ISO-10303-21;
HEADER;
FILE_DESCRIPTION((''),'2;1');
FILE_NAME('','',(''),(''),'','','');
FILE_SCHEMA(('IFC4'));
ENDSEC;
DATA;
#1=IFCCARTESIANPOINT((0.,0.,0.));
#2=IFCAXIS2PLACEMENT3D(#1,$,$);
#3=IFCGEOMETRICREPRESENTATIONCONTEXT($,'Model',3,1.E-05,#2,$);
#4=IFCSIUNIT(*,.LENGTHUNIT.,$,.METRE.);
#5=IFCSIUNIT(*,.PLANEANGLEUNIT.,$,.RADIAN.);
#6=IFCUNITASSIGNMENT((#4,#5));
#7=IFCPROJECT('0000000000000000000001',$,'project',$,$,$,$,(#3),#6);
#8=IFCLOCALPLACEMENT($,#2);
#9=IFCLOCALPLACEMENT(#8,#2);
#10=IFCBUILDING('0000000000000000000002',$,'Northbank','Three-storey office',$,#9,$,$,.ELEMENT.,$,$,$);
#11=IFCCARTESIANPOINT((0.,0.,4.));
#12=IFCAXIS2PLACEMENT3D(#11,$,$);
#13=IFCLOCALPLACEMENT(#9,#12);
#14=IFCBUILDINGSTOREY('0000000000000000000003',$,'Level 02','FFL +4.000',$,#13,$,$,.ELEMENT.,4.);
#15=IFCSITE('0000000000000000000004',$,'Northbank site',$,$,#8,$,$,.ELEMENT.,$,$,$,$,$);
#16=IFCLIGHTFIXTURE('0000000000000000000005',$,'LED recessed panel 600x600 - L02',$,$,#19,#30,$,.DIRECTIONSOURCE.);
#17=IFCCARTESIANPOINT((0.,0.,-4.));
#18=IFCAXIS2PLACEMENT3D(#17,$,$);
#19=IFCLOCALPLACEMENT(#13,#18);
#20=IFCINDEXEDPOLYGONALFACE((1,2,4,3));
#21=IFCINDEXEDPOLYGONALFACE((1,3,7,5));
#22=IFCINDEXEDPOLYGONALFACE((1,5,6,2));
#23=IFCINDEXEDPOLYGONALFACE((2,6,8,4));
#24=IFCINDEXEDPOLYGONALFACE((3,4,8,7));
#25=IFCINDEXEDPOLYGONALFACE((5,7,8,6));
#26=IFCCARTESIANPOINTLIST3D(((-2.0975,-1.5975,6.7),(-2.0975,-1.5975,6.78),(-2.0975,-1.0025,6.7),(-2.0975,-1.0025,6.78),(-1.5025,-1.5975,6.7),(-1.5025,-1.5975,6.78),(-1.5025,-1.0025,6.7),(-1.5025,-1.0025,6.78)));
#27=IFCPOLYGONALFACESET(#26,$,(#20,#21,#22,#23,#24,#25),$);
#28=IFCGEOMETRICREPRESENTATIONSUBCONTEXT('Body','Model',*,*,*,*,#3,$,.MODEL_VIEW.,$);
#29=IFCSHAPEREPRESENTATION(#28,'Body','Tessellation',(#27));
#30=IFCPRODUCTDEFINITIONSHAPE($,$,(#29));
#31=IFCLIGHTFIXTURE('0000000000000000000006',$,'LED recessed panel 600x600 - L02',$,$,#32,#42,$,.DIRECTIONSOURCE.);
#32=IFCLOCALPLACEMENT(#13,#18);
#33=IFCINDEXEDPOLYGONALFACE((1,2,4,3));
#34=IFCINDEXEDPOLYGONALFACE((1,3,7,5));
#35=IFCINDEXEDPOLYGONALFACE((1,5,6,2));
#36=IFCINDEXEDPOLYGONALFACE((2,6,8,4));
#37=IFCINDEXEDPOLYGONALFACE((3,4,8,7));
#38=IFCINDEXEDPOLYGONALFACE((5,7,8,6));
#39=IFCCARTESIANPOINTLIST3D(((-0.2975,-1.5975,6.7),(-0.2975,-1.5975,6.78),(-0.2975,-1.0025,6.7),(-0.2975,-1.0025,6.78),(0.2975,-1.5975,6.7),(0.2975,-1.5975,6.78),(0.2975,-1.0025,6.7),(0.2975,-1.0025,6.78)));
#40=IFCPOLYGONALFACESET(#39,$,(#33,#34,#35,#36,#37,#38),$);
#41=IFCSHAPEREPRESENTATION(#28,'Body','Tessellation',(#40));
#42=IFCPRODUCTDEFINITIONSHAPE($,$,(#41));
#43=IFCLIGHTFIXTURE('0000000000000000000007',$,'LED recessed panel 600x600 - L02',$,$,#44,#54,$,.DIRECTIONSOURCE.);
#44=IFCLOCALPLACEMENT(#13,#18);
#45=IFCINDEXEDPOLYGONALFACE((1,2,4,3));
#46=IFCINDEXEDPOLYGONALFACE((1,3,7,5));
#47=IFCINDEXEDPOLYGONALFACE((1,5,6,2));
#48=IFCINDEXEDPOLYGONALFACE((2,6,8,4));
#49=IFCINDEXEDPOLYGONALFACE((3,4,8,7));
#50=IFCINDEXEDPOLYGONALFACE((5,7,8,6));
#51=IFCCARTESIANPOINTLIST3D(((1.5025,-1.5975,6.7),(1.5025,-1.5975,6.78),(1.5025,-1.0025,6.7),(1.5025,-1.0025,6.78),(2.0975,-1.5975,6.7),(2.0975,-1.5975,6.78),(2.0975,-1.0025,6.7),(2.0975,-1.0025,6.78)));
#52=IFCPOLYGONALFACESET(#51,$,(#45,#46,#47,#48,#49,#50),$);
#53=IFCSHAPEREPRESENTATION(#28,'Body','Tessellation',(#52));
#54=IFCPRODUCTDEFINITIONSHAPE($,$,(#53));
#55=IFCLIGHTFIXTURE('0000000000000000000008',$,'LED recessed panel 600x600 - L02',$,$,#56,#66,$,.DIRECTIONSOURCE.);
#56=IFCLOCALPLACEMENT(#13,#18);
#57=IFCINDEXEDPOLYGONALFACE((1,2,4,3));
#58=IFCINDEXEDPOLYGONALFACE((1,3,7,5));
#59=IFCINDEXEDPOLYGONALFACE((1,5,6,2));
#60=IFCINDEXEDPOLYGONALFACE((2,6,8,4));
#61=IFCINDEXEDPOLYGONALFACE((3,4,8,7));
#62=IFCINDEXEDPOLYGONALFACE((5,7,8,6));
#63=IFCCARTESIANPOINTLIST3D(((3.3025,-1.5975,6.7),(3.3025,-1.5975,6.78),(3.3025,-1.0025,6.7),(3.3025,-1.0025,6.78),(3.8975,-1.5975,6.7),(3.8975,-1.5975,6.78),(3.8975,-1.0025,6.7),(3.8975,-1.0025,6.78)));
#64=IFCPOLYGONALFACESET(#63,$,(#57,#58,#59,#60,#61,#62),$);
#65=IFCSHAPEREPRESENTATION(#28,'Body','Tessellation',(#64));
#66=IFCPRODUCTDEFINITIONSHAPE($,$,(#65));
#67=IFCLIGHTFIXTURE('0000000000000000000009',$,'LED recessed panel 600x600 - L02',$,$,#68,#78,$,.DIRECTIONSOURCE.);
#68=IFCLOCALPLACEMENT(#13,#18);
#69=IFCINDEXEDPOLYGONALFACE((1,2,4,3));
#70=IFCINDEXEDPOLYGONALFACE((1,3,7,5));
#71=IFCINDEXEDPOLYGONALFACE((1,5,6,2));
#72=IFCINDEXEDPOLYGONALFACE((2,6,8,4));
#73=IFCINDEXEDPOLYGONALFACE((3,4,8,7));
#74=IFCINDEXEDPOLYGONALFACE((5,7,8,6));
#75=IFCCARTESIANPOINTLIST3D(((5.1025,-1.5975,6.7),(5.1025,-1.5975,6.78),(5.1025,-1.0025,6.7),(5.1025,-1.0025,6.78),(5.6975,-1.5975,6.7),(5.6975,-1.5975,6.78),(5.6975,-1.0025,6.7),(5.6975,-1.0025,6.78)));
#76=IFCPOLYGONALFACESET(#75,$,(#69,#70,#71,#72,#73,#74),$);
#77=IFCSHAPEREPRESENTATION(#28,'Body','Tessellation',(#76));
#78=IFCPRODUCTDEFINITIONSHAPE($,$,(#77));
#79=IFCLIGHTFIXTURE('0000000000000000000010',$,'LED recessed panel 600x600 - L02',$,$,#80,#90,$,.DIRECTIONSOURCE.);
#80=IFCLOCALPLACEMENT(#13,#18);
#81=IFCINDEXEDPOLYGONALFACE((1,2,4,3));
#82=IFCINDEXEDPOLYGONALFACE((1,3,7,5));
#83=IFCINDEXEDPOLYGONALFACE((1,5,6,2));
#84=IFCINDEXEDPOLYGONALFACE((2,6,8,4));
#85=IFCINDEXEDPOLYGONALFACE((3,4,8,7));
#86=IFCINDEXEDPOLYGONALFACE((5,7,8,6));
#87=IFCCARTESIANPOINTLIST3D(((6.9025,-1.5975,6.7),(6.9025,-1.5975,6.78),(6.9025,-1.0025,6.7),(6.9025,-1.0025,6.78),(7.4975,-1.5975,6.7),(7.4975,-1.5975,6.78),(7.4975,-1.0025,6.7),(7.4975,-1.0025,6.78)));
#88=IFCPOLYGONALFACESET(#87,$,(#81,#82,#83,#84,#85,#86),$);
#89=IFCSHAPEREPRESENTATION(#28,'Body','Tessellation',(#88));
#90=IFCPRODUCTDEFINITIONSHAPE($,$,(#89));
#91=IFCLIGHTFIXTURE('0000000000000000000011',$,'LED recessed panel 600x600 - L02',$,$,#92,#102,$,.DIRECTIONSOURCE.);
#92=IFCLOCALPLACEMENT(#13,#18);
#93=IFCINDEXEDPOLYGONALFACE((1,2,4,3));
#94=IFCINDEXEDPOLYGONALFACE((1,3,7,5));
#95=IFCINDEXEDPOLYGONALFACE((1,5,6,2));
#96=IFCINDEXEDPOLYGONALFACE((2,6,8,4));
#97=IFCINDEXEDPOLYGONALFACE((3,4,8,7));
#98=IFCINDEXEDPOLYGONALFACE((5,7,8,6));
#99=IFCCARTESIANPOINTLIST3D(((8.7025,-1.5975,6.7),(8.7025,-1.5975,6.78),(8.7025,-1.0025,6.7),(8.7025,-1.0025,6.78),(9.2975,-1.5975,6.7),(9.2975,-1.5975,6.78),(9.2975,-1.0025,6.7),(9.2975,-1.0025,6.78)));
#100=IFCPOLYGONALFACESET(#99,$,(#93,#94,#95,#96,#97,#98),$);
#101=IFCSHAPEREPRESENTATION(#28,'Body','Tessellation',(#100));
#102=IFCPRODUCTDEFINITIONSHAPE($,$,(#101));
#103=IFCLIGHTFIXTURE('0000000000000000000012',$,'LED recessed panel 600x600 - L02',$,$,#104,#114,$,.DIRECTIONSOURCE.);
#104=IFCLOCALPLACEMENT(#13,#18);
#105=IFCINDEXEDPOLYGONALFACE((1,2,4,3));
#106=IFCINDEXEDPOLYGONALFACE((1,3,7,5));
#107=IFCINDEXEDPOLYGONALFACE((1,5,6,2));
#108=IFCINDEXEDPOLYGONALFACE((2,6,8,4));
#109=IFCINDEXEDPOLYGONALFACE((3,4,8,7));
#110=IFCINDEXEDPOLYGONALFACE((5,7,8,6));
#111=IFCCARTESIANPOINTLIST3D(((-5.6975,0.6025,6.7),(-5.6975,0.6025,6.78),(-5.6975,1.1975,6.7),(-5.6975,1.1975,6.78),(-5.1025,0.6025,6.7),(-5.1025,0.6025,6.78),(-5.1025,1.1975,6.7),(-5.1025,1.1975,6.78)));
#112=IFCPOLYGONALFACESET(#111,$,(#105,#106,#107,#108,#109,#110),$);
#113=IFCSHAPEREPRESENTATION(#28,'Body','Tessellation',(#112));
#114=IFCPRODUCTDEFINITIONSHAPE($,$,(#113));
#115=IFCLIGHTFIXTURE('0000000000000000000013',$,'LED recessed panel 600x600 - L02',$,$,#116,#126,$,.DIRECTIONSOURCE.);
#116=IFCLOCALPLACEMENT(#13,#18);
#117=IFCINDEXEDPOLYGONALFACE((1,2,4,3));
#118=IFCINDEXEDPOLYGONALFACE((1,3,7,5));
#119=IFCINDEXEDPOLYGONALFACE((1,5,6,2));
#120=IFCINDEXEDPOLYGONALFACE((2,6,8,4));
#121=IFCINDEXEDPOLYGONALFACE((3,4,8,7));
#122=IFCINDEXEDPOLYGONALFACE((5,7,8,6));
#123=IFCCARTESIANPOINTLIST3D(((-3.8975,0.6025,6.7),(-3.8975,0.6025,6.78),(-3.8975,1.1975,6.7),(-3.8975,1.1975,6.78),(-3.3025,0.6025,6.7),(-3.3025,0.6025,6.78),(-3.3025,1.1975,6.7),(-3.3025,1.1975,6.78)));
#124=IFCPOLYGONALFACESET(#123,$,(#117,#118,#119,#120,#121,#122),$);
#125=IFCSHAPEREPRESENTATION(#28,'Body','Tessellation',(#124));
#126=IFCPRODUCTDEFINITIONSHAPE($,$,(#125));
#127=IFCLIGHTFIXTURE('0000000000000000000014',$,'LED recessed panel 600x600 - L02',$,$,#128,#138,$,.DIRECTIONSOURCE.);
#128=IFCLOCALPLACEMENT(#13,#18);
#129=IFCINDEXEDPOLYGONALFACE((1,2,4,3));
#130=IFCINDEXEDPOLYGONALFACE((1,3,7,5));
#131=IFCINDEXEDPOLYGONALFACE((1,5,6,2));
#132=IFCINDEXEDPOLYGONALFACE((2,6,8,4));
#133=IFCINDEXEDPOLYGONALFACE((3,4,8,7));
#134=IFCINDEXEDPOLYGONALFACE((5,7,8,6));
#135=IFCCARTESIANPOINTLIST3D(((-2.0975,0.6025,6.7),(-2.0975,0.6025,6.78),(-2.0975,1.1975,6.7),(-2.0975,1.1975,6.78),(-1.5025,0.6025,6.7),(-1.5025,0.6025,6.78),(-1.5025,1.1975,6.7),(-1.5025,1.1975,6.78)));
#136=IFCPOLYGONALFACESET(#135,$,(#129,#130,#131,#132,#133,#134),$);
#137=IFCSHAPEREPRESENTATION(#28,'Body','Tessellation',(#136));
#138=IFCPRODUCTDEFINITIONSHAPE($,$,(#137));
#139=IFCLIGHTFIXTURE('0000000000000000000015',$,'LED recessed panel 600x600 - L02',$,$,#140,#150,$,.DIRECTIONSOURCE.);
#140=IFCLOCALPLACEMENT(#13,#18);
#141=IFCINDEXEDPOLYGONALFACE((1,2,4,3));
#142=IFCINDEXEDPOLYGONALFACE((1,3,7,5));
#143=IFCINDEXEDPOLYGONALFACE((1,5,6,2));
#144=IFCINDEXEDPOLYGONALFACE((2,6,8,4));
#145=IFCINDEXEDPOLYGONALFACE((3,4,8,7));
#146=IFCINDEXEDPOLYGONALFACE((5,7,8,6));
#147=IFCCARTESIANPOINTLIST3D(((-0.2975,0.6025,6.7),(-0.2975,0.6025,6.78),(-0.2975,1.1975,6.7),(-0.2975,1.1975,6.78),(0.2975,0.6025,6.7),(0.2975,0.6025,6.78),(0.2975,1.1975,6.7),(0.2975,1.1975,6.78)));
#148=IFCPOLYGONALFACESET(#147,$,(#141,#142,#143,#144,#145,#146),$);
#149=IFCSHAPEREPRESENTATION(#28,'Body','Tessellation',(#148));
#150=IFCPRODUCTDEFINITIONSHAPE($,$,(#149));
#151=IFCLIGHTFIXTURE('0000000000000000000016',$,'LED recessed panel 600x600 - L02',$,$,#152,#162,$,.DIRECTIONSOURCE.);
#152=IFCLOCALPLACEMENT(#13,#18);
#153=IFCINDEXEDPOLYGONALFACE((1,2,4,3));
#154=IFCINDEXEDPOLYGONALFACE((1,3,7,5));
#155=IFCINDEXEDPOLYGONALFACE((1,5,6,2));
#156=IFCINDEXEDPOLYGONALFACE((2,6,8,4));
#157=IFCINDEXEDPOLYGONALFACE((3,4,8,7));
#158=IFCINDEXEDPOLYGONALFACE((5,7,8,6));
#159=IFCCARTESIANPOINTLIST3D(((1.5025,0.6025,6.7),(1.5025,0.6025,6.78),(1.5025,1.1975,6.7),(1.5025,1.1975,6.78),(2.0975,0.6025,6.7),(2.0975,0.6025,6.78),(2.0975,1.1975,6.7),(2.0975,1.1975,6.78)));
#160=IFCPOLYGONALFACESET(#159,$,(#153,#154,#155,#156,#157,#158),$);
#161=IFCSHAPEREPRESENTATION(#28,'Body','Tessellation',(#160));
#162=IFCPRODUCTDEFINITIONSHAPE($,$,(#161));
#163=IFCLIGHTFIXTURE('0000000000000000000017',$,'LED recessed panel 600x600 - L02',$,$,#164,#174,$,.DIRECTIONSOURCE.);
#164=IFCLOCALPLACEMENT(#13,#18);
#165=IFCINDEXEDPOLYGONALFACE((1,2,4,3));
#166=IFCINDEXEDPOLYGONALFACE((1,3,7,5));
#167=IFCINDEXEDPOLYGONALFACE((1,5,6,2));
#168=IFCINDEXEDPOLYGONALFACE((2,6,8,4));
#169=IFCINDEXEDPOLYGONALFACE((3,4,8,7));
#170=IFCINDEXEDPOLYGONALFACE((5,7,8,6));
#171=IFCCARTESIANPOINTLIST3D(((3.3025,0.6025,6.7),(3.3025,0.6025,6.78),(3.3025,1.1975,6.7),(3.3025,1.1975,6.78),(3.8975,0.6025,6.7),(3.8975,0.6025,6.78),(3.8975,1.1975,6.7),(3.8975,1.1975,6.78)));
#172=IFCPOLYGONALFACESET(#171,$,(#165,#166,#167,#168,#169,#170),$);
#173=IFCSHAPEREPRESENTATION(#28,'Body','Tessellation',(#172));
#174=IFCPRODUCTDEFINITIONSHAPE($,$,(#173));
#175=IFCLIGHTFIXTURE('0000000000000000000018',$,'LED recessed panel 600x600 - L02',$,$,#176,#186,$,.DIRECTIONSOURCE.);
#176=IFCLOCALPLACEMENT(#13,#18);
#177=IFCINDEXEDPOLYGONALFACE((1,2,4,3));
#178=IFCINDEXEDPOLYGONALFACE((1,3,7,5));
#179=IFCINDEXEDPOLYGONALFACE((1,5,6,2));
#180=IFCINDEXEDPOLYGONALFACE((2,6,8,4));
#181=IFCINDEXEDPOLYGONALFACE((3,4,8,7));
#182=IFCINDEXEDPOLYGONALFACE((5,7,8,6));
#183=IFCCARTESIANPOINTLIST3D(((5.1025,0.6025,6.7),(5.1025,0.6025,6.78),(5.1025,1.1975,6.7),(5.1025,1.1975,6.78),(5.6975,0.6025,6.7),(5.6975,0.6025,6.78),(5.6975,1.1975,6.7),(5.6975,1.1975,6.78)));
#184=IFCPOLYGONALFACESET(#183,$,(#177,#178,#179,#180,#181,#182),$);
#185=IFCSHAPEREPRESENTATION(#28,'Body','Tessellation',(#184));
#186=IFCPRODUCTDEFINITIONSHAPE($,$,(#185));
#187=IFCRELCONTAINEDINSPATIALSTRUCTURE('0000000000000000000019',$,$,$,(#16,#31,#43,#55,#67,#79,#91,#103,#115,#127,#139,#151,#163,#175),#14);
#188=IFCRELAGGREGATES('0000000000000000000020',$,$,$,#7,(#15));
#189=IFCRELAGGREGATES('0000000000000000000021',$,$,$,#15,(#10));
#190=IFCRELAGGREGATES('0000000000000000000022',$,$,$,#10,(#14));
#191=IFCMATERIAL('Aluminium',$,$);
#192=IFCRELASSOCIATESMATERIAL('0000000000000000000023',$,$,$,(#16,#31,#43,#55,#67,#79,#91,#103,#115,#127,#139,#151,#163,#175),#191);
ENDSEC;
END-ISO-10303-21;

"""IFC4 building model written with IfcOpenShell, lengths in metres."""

from ifc_helpers import new_model, si_unit, frame, origin, place, context, subcontext, project, spatial, rectangle, extrude, material, element, save


model = new_model("IFC4")

# Units and contexts
model_context = context("Model", 3, precision=1e-05, world=origin())
body_context = subcontext(model_context, "Body", "Model", "MODEL_VIEW")
ifc_project = project(units=[si_unit("LENGTHUNIT", "METRE"), si_unit("PLANEANGLEUNIT", "RADIAN")], contexts=[model_context])

# Site, building, storey
site_placement = place(None, origin())
site = spatial("IfcSite", under=ifc_project, at=site_placement, Name="Northbank site", CompositionType="ELEMENT")
building_placement = place(site_placement, origin())
building = spatial("IfcBuilding", under=site, at=building_placement, Name="Northbank", Description="Three-storey office", CompositionType="ELEMENT")
storey_placement = place(building_placement, frame((0.0, 0.0, 4.0)))
storey = spatial("IfcBuildingStorey", under=building, at=storey_placement, Name="Level 02", Description="FFL +4.000", CompositionType="ELEMENT", Elevation=4.0)

# Light fixtures
ifc_material = material(Name="Aluminium")
light_fixture_1_placement = place(storey_placement, frame((0.0, 0.0, -4.0)))
element("IfcLightFixture", 1, at=light_fixture_1_placement, inside=storey, material=ifc_material, Name="LED recessed panel 600x600 - L02", PredefinedType="DIRECTIONSOURCE", context=body_context, shape_type="SweptSolid", body=[
    extrude(rectangle(XDim=0.595, YDim=0.595), frame((-1.8, -1.3, 6.7)), (0.0, 0.0, 1.0), 0.08),
])
light_fixture_2_placement = place(storey_placement, frame((0.0, 0.0, -4.0)))
element("IfcLightFixture", 2, at=light_fixture_2_placement, inside=storey, material=ifc_material, Name="LED recessed panel 600x600 - L02", PredefinedType="DIRECTIONSOURCE", context=body_context, shape_type="SweptSolid", body=[
    extrude(rectangle(XDim=0.595, YDim=0.595), frame((0.0, -1.3, 6.7)), (0.0, 0.0, 1.0), 0.08),
])
light_fixture_3_placement = place(storey_placement, frame((0.0, 0.0, -4.0)))
element("IfcLightFixture", 3, at=light_fixture_3_placement, inside=storey, material=ifc_material, Name="LED recessed panel 600x600 - L02", PredefinedType="DIRECTIONSOURCE", context=body_context, shape_type="SweptSolid", body=[
    extrude(rectangle(XDim=0.595, YDim=0.595), frame((1.8, -1.3, 6.7)), (0.0, 0.0, 1.0), 0.08),
])
light_fixture_4_placement = place(storey_placement, frame((0.0, 0.0, -4.0)))
element("IfcLightFixture", 4, at=light_fixture_4_placement, inside=storey, material=ifc_material, Name="LED recessed panel 600x600 - L02", PredefinedType="DIRECTIONSOURCE", context=body_context, shape_type="SweptSolid", body=[
    extrude(rectangle(XDim=0.595, YDim=0.595), frame((3.6, -1.3, 6.7)), (0.0, 0.0, 1.0), 0.08),
])
light_fixture_5_placement = place(storey_placement, frame((0.0, 0.0, -4.0)))
element("IfcLightFixture", 5, at=light_fixture_5_placement, inside=storey, material=ifc_material, Name="LED recessed panel 600x600 - L02", PredefinedType="DIRECTIONSOURCE", context=body_context, shape_type="SweptSolid", body=[
    extrude(rectangle(XDim=0.595, YDim=0.595), frame((5.4, -1.3, 6.7)), (0.0, 0.0, 1.0), 0.08),
])
light_fixture_6_placement = place(storey_placement, frame((0.0, 0.0, -4.0)))
element("IfcLightFixture", 6, at=light_fixture_6_placement, inside=storey, material=ifc_material, Name="LED recessed panel 600x600 - L02", PredefinedType="DIRECTIONSOURCE", context=body_context, shape_type="SweptSolid", body=[
    extrude(rectangle(XDim=0.595, YDim=0.595), frame((7.2, -1.3, 6.7)), (0.0, 0.0, 1.0), 0.08),
])
light_fixture_7_placement = place(storey_placement, frame((0.0, 0.0, -4.0)))
element("IfcLightFixture", 7, at=light_fixture_7_placement, inside=storey, material=ifc_material, Name="LED recessed panel 600x600 - L02", PredefinedType="DIRECTIONSOURCE", context=body_context, shape_type="SweptSolid", body=[
    extrude(rectangle(XDim=0.595, YDim=0.595), frame((9.0, -1.3, 6.7)), (0.0, 0.0, 1.0), 0.08),
])
light_fixture_8_placement = place(storey_placement, frame((0.0, 0.0, -4.0)))
element("IfcLightFixture", 8, at=light_fixture_8_placement, inside=storey, material=ifc_material, Name="LED recessed panel 600x600 - L02", PredefinedType="DIRECTIONSOURCE", context=body_context, shape_type="SweptSolid", body=[
    extrude(rectangle(XDim=0.595, YDim=0.595), frame((-5.4, 0.9, 6.7)), (0.0, 0.0, 1.0), 0.08),
])
light_fixture_9_placement = place(storey_placement, frame((0.0, 0.0, -4.0)))
element("IfcLightFixture", 9, at=light_fixture_9_placement, inside=storey, material=ifc_material, Name="LED recessed panel 600x600 - L02", PredefinedType="DIRECTIONSOURCE", context=body_context, shape_type="SweptSolid", body=[
    extrude(rectangle(XDim=0.595, YDim=0.595), frame((-3.6, 0.9, 6.7)), (0.0, 0.0, 1.0), 0.08),
])
light_fixture_10_placement = place(storey_placement, frame((0.0, 0.0, -4.0)))
element("IfcLightFixture", 10, at=light_fixture_10_placement, inside=storey, material=ifc_material, Name="LED recessed panel 600x600 - L02", PredefinedType="DIRECTIONSOURCE", context=body_context, shape_type="SweptSolid", body=[
    extrude(rectangle(XDim=0.595, YDim=0.595), frame((-1.8, 0.9, 6.7)), (0.0, 0.0, 1.0), 0.08),
])
light_fixture_11_placement = place(storey_placement, frame((0.0, 0.0, -4.0)))
element("IfcLightFixture", 11, at=light_fixture_11_placement, inside=storey, material=ifc_material, Name="LED recessed panel 600x600 - L02", PredefinedType="DIRECTIONSOURCE", context=body_context, shape_type="SweptSolid", body=[
    extrude(rectangle(XDim=0.595, YDim=0.595), frame((0.0, 0.9, 6.7)), (0.0, 0.0, 1.0), 0.08),
])
light_fixture_12_placement = place(storey_placement, frame((0.0, 0.0, -4.0)))
element("IfcLightFixture", 12, at=light_fixture_12_placement, inside=storey, material=ifc_material, Name="LED recessed panel 600x600 - L02", PredefinedType="DIRECTIONSOURCE", context=body_context, shape_type="SweptSolid", body=[
    extrude(rectangle(XDim=0.595, YDim=0.595), frame((1.8, 0.9, 6.7)), (0.0, 0.0, 1.0), 0.08),
])
light_fixture_13_placement = place(storey_placement, frame((0.0, 0.0, -4.0)))
element("IfcLightFixture", 13, at=light_fixture_13_placement, inside=storey, material=ifc_material, Name="LED recessed panel 600x600 - L02", PredefinedType="DIRECTIONSOURCE", context=body_context, shape_type="SweptSolid", body=[
    extrude(rectangle(XDim=0.595, YDim=0.595), frame((3.6, 0.9, 6.7)), (0.0, 0.0, 1.0), 0.08),
])
light_fixture_14_placement = place(storey_placement, frame((0.0, 0.0, -4.0)))
element("IfcLightFixture", 14, at=light_fixture_14_placement, inside=storey, material=ifc_material, Name="LED recessed panel 600x600 - L02", PredefinedType="DIRECTIONSOURCE", context=body_context, shape_type="SweptSolid", body=[
    extrude(rectangle(XDim=0.595, YDim=0.595), frame((5.4, 0.9, 6.7)), (0.0, 0.0, 1.0), 0.08),
])

save(model, "model.ifc")
